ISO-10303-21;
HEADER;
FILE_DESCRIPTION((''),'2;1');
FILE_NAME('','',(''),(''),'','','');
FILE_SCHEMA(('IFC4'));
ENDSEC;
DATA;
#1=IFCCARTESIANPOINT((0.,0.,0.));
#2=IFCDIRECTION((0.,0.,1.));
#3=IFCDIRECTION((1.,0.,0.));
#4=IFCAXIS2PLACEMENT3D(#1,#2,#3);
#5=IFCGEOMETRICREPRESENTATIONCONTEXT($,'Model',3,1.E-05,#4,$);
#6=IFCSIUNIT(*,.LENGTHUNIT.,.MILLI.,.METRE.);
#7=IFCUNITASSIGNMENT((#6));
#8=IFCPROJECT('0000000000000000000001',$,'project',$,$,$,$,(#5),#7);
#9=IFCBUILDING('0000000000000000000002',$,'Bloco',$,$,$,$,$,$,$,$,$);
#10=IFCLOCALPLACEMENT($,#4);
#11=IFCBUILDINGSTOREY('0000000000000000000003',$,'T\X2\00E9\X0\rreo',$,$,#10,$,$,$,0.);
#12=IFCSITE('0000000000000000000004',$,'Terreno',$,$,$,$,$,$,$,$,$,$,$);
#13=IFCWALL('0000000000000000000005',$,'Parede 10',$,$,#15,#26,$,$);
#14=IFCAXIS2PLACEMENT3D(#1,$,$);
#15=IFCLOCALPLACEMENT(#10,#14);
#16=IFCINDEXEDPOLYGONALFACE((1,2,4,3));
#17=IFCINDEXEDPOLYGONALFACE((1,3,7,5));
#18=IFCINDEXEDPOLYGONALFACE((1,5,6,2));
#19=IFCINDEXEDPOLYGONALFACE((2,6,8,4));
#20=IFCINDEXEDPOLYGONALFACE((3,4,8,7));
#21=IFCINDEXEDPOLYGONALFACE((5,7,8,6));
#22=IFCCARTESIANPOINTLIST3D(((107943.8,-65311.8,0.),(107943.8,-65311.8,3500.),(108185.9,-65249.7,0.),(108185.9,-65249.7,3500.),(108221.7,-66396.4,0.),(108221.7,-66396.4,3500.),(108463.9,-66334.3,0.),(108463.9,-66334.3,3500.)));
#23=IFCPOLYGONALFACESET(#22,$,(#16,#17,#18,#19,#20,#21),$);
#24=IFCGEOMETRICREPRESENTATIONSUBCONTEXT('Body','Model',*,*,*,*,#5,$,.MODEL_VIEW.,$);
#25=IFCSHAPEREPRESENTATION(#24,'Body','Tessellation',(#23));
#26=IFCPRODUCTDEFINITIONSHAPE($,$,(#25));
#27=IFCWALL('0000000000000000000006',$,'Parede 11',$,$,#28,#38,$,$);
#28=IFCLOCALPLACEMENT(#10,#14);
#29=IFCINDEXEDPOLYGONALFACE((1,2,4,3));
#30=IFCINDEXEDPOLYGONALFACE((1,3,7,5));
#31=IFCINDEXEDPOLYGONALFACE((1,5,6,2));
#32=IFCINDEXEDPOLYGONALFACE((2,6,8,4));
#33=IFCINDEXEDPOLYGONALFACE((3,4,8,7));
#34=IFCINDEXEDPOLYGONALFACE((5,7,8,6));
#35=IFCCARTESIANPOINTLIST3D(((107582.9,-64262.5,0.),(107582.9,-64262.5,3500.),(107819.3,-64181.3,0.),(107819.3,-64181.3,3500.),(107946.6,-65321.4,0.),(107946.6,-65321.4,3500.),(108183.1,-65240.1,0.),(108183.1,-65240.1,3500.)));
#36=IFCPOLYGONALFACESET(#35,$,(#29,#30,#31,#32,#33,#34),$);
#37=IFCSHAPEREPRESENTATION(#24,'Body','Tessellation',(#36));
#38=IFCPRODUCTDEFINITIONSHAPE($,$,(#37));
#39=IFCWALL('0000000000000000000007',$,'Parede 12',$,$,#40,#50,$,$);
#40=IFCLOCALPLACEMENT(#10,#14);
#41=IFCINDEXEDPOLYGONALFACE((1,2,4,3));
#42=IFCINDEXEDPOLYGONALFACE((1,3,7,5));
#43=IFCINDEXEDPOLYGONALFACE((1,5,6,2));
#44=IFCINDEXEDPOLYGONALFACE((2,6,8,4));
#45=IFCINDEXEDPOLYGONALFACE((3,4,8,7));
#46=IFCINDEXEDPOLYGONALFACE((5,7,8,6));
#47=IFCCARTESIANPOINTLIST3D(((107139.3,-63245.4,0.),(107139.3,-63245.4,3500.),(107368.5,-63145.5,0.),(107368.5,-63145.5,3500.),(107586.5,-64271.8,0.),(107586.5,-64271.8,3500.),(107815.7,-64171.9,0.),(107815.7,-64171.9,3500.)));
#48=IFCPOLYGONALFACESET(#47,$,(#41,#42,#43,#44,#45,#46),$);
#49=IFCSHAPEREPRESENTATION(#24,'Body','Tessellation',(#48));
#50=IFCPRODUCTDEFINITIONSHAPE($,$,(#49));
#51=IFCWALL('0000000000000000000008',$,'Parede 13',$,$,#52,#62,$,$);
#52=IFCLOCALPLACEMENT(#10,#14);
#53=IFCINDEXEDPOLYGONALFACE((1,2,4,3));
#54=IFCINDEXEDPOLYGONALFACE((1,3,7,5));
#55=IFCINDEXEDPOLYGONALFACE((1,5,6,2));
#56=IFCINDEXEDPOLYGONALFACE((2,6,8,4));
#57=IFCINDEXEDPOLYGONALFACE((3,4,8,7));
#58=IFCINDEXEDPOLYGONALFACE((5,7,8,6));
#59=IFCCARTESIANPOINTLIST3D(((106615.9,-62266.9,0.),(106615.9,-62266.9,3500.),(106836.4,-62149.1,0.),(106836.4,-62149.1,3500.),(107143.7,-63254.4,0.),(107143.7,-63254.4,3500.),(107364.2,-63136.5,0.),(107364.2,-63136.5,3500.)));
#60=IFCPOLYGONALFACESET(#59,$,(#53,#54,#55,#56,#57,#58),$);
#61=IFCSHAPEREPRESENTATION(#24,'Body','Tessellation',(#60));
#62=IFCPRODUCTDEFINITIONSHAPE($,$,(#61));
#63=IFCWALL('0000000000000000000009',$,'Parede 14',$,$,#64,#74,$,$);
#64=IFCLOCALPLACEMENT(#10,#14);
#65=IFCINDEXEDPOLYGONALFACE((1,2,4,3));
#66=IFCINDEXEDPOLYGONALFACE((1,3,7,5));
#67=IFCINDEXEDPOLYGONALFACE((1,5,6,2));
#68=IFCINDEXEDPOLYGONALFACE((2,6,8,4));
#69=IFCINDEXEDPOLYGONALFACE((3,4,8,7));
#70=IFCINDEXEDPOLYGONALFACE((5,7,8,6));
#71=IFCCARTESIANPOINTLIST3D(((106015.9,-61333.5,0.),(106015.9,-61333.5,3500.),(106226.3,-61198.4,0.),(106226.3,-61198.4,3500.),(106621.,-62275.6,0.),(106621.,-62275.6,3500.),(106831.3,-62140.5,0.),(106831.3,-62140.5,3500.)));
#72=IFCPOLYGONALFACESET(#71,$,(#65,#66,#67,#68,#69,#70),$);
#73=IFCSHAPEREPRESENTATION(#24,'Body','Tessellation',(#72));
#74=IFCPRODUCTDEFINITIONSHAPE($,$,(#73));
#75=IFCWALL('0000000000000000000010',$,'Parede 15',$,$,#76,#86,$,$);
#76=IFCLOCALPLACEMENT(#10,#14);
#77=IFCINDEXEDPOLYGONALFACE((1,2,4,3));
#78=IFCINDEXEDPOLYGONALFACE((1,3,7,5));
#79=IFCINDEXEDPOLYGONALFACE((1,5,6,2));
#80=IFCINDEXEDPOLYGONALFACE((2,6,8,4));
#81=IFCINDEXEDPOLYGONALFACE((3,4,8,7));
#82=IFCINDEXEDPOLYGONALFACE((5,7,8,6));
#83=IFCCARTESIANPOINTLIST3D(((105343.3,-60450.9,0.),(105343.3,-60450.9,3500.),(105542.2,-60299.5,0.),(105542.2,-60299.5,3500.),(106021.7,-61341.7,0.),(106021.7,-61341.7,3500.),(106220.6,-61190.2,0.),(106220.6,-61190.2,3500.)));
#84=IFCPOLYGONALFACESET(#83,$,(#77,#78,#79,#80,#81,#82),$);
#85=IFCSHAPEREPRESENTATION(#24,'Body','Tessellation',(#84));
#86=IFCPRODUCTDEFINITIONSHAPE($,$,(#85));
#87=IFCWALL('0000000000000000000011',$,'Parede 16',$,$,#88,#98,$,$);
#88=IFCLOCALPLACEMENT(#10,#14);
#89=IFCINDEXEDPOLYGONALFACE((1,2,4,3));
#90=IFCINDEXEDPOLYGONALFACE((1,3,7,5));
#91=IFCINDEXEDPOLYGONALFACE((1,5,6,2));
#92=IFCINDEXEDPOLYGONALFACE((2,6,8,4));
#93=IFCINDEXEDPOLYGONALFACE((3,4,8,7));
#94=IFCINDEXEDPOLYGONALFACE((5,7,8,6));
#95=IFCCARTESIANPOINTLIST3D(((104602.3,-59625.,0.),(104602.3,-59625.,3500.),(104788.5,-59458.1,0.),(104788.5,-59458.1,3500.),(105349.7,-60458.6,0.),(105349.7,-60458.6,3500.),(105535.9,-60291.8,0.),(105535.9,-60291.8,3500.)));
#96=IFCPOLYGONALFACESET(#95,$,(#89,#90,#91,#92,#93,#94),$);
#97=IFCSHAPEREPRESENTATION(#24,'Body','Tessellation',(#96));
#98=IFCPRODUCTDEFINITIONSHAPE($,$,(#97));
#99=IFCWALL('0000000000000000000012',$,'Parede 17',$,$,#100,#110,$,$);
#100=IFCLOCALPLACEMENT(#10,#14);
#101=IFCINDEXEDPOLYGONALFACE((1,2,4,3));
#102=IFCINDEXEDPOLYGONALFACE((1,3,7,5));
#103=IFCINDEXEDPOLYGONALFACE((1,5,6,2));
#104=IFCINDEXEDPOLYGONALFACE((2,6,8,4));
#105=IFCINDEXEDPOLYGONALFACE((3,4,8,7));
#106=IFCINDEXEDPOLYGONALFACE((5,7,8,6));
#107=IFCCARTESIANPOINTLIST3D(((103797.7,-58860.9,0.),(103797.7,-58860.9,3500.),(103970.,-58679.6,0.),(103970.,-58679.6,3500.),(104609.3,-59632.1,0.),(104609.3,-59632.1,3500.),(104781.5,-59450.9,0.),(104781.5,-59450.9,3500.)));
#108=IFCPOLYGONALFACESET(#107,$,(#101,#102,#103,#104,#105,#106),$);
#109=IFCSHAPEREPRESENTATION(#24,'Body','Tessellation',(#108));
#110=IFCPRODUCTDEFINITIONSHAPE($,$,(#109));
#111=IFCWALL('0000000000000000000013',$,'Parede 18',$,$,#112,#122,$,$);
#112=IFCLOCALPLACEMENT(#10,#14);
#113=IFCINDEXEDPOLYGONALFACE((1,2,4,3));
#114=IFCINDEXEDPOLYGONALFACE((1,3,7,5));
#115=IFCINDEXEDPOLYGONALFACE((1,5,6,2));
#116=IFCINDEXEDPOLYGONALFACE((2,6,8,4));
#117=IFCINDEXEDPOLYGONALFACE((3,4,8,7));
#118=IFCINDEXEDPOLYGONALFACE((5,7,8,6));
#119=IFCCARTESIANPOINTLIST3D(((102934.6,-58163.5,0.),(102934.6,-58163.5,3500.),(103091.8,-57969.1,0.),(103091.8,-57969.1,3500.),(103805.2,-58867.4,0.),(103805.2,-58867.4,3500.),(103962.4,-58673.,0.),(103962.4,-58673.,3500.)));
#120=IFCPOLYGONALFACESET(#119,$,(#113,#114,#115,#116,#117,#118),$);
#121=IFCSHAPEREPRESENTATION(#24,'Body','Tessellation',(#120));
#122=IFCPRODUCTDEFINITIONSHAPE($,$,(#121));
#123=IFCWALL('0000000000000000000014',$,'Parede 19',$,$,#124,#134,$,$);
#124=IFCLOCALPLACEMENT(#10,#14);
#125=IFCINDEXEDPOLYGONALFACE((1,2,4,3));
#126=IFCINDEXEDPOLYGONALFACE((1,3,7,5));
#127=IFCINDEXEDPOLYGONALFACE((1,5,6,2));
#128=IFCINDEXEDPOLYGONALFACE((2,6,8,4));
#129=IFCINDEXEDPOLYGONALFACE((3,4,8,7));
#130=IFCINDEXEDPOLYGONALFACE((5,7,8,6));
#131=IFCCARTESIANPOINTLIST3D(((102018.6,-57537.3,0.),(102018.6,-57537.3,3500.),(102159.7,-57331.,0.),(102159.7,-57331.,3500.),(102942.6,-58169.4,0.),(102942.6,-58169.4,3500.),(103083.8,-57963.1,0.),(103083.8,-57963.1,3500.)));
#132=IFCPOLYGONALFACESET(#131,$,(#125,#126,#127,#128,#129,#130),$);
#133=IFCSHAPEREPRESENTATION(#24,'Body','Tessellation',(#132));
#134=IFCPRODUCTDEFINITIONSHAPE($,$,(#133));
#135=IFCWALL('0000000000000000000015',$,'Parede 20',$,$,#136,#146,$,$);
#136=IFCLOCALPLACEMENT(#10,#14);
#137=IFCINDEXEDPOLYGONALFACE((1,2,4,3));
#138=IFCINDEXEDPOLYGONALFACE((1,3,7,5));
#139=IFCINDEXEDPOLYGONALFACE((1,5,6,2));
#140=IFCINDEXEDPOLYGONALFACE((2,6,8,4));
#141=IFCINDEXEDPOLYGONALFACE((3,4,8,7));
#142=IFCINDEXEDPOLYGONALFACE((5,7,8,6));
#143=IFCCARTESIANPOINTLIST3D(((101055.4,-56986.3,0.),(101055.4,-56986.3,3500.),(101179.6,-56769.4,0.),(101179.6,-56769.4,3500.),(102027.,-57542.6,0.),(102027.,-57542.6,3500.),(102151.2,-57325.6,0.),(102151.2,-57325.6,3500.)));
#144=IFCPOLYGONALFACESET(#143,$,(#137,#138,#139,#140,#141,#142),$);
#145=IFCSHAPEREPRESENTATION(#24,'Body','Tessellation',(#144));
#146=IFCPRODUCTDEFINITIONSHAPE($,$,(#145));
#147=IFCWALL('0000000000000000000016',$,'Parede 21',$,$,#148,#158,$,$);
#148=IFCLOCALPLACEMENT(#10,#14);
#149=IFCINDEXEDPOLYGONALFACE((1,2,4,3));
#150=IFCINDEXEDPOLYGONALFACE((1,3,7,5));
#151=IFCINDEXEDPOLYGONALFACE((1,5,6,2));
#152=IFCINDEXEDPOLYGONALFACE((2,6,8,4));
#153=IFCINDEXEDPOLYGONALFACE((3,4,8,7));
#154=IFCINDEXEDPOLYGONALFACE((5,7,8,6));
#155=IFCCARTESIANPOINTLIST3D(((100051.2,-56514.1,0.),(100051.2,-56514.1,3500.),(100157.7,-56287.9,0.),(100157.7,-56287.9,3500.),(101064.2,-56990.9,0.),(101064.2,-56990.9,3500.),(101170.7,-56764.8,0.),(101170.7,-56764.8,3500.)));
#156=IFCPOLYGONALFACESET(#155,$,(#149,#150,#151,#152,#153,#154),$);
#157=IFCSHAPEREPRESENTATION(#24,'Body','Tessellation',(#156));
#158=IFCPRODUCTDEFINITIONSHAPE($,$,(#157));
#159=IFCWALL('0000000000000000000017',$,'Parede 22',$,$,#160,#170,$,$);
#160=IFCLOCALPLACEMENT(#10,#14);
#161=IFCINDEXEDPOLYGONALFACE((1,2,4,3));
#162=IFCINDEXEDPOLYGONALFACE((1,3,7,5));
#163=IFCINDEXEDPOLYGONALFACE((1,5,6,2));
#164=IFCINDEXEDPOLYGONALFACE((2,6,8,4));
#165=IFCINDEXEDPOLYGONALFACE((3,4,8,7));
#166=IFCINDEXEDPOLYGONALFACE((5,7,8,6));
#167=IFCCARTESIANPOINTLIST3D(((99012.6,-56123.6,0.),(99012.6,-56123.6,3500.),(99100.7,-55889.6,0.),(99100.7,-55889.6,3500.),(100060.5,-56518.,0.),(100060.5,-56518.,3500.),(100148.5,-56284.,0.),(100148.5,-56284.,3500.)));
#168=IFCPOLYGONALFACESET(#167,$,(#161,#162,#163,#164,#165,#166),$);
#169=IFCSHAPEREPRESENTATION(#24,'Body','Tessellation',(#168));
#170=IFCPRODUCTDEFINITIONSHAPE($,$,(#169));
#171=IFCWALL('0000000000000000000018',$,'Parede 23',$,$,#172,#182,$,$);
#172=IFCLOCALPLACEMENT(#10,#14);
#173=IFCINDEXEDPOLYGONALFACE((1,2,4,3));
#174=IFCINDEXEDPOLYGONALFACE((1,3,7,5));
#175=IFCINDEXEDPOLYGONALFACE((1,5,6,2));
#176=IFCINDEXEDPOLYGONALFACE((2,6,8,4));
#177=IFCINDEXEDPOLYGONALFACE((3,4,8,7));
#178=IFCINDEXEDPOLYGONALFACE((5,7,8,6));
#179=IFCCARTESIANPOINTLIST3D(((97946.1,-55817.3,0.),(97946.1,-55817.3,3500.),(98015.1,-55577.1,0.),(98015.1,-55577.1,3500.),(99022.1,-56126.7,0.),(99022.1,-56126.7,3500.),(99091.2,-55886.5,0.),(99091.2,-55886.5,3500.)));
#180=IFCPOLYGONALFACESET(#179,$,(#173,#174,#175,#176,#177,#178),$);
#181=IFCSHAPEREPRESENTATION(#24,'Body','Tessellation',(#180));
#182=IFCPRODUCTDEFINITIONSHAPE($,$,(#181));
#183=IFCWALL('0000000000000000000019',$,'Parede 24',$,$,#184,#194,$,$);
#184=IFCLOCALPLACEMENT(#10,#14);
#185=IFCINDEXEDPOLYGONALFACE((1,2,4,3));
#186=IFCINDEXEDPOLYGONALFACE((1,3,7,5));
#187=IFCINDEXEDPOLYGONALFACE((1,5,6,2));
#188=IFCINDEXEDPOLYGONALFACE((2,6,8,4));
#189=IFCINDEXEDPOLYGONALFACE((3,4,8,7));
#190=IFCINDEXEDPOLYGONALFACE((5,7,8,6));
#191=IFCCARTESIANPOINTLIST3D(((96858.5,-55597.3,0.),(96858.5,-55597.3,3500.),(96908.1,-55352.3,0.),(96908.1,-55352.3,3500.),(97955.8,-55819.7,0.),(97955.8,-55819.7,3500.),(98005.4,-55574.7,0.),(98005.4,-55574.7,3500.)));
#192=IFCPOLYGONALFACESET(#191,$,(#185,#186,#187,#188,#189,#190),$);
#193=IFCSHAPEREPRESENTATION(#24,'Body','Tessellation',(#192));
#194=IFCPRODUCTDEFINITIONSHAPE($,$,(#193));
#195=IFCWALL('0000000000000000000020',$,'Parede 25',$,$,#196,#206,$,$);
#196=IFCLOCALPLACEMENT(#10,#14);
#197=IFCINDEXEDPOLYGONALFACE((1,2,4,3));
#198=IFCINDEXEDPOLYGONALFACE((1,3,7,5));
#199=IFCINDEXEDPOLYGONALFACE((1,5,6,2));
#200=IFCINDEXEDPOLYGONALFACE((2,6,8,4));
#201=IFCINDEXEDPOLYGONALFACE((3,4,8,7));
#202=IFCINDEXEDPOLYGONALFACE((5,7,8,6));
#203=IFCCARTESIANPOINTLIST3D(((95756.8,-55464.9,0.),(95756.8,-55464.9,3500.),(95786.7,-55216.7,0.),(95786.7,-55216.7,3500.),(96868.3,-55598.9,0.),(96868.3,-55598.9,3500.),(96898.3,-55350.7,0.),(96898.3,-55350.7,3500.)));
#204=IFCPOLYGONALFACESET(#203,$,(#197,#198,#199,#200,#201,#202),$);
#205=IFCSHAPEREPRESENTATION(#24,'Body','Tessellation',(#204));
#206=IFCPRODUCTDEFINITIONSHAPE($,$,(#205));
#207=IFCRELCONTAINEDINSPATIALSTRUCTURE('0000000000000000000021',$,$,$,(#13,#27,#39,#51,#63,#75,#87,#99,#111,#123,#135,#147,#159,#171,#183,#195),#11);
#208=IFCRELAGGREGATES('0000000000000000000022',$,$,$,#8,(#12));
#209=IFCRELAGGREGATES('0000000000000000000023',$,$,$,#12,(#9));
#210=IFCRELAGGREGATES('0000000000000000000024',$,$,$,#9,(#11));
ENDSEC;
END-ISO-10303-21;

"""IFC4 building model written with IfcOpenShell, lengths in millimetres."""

from ifc_helpers import new_model, si_unit, origin, origin_with_axes, place, context, subcontext, project, spatial, polyline, outline, extrude, element, save


model = new_model("IFC4")

# Units and contexts
model_context = context("Model", 3, precision=1e-05, world=origin_with_axes())
body_context = subcontext(model_context, "Body", "Model", "MODEL_VIEW")
ifc_project = project(units=[si_unit("LENGTHUNIT", "METRE", prefix="MILLI")], contexts=[model_context])

# Site, building, storey
site = spatial("IfcSite", under=ifc_project, Name="Terreno")
building = spatial("IfcBuilding", under=site, Name="Bloco")
storey_placement = place(None, origin_with_axes())
storey = spatial("IfcBuildingStorey", under=building, at=storey_placement, Name="Térreo", Elevation=0.0)

# Walls
wall_1_placement = place(storey_placement, origin_with_axes())
element("IfcWall", 1, at=wall_1_placement, inside=storey, Name="Parede 10", context=body_context, shape_type="SweptSolid", body=[
    extrude(outline(polyline([(108221.7, -66396.4), (107943.8, -65311.8), (108185.9, -65249.7), (108463.9, -66334.3), (108221.7, -66396.4)])), origin(), (0.0, 0.0, 1.0), 3500.0),
])
wall_2_placement = place(storey_placement, origin_with_axes())
element("IfcWall", 2, at=wall_2_placement, inside=storey, Name="Parede 11", context=body_context, shape_type="SweptSolid", body=[
    extrude(outline(polyline([(107946.6, -65321.4), (107582.9, -64262.5), (107819.3, -64181.3), (108183.1, -65240.1), (107946.6, -65321.4)])), origin(), (0.0, 0.0, 1.0), 3500.0),
])
wall_3_placement = place(storey_placement, origin_with_axes())
element("IfcWall", 3, at=wall_3_placement, inside=storey, Name="Parede 12", context=body_context, shape_type="SweptSolid", body=[
    extrude(outline(polyline([(107586.5, -64271.8), (107139.3, -63245.4), (107368.5, -63145.5), (107815.7, -64171.9), (107586.5, -64271.8)])), origin(), (0.0, 0.0, 1.0), 3500.0),
])
wall_4_placement = place(storey_placement, origin_with_axes())
element("IfcWall", 4, at=wall_4_placement, inside=storey, Name="Parede 13", context=body_context, shape_type="SweptSolid", body=[
    extrude(outline(polyline([(107143.7, -63254.4), (106615.9, -62266.9), (106836.4, -62149.1), (107364.2, -63136.5), (107143.7, -63254.4)])), origin(), (0.0, 0.0, 1.0), 3500.0),
])
wall_5_placement = place(storey_placement, origin_with_axes())
element("IfcWall", 5, at=wall_5_placement, inside=storey, Name="Parede 14", context=body_context, shape_type="SweptSolid", body=[
    extrude(outline(polyline([(106621.0, -62275.6), (106015.9, -61333.5), (106226.3, -61198.4), (106831.3, -62140.5), (106621.0, -62275.6)])), origin(), (0.0, 0.0, 1.0), 3500.0),
])
wall_6_placement = place(storey_placement, origin_with_axes())
element("IfcWall", 6, at=wall_6_placement, inside=storey, Name="Parede 15", context=body_context, shape_type="SweptSolid", body=[
    extrude(outline(polyline([(106021.7, -61341.7), (105343.3, -60450.9), (105542.2, -60299.5), (106220.6, -61190.2), (106021.7, -61341.7)])), origin(), (0.0, 0.0, 1.0), 3500.0),
])
wall_7_placement = place(storey_placement, origin_with_axes())
element("IfcWall", 7, at=wall_7_placement, inside=storey, Name="Parede 16", context=body_context, shape_type="SweptSolid", body=[
    extrude(outline(polyline([(105349.7, -60458.6), (104602.3, -59625.0), (104788.5, -59458.1), (105535.9, -60291.8), (105349.7, -60458.6)])), origin(), (0.0, 0.0, 1.0), 3500.0),
])
wall_8_placement = place(storey_placement, origin_with_axes())
element("IfcWall", 8, at=wall_8_placement, inside=storey, Name="Parede 17", context=body_context, shape_type="SweptSolid", body=[
    extrude(outline(polyline([(104609.3, -59632.1), (103797.7, -58860.9), (103970.0, -58679.6), (104781.5, -59450.9), (104609.3, -59632.1)])), origin(), (0.0, 0.0, 1.0), 3500.0),
])
wall_9_placement = place(storey_placement, origin_with_axes())
element("IfcWall", 9, at=wall_9_placement, inside=storey, Name="Parede 18", context=body_context, shape_type="SweptSolid", body=[
    extrude(outline(polyline([(103805.2, -58867.4), (102934.6, -58163.5), (103091.8, -57969.1), (103962.4, -58673.0), (103805.2, -58867.4)])), origin(), (0.0, 0.0, 1.0), 3500.0),
])
wall_10_placement = place(storey_placement, origin_with_axes())
element("IfcWall", 10, at=wall_10_placement, inside=storey, Name="Parede 19", context=body_context, shape_type="SweptSolid", body=[
    extrude(outline(polyline([(102942.6, -58169.4), (102018.6, -57537.3), (102159.7, -57331.0), (103083.8, -57963.1), (102942.6, -58169.4)])), origin(), (0.0, 0.0, 1.0), 3500.0),
])
wall_11_placement = place(storey_placement, origin_with_axes())
element("IfcWall", 11, at=wall_11_placement, inside=storey, Name="Parede 20", context=body_context, shape_type="SweptSolid", body=[
    extrude(outline(polyline([(102027.0, -57542.6), (101055.4, -56986.3), (101179.6, -56769.4), (102151.2, -57325.6), (102027.0, -57542.6)])), origin(), (0.0, 0.0, 1.0), 3500.0),
])
wall_12_placement = place(storey_placement, origin_with_axes())
element("IfcWall", 12, at=wall_12_placement, inside=storey, Name="Parede 21", context=body_context, shape_type="SweptSolid", body=[
    extrude(outline(polyline([(101064.2, -56990.9), (100051.2, -56514.1), (100157.7, -56287.9), (101170.7, -56764.8), (101064.2, -56990.9)])), origin(), (0.0, 0.0, 1.0), 3500.0),
])
wall_13_placement = place(storey_placement, origin_with_axes())
element("IfcWall", 13, at=wall_13_placement, inside=storey, Name="Parede 22", context=body_context, shape_type="SweptSolid", body=[
    extrude(outline(polyline([(100060.5, -56518.0), (99012.6, -56123.6), (99100.7, -55889.6), (100148.5, -56284.0), (100060.5, -56518.0)])), origin(), (0.0, 0.0, 1.0), 3500.0),
])
wall_14_placement = place(storey_placement, origin_with_axes())
element("IfcWall", 14, at=wall_14_placement, inside=storey, Name="Parede 23", context=body_context, shape_type="SweptSolid", body=[
    extrude(outline(polyline([(99022.1, -56126.7), (97946.1, -55817.3), (98015.1, -55577.1), (99091.2, -55886.5), (99022.1, -56126.7)])), origin(), (0.0, 0.0, 1.0), 3500.0),
])
wall_15_placement = place(storey_placement, origin_with_axes())
element("IfcWall", 15, at=wall_15_placement, inside=storey, Name="Parede 24", context=body_context, shape_type="SweptSolid", body=[
    extrude(outline(polyline([(97955.8, -55819.7), (96858.5, -55597.3), (96908.1, -55352.3), (98005.4, -55574.7), (97955.8, -55819.7)])), origin(), (0.0, 0.0, 1.0), 3500.0),
])
wall_16_placement = place(storey_placement, origin_with_axes())
element("IfcWall", 16, at=wall_16_placement, inside=storey, Name="Parede 25", context=body_context, shape_type="SweptSolid", body=[
    extrude(outline(polyline([(96868.3, -55598.9), (95756.8, -55464.9), (95786.7, -55216.7), (96898.3, -55350.7), (96868.3, -55598.9)])), origin(), (0.0, 0.0, 1.0), 3500.0),
])

save(model, "model.ifc")
